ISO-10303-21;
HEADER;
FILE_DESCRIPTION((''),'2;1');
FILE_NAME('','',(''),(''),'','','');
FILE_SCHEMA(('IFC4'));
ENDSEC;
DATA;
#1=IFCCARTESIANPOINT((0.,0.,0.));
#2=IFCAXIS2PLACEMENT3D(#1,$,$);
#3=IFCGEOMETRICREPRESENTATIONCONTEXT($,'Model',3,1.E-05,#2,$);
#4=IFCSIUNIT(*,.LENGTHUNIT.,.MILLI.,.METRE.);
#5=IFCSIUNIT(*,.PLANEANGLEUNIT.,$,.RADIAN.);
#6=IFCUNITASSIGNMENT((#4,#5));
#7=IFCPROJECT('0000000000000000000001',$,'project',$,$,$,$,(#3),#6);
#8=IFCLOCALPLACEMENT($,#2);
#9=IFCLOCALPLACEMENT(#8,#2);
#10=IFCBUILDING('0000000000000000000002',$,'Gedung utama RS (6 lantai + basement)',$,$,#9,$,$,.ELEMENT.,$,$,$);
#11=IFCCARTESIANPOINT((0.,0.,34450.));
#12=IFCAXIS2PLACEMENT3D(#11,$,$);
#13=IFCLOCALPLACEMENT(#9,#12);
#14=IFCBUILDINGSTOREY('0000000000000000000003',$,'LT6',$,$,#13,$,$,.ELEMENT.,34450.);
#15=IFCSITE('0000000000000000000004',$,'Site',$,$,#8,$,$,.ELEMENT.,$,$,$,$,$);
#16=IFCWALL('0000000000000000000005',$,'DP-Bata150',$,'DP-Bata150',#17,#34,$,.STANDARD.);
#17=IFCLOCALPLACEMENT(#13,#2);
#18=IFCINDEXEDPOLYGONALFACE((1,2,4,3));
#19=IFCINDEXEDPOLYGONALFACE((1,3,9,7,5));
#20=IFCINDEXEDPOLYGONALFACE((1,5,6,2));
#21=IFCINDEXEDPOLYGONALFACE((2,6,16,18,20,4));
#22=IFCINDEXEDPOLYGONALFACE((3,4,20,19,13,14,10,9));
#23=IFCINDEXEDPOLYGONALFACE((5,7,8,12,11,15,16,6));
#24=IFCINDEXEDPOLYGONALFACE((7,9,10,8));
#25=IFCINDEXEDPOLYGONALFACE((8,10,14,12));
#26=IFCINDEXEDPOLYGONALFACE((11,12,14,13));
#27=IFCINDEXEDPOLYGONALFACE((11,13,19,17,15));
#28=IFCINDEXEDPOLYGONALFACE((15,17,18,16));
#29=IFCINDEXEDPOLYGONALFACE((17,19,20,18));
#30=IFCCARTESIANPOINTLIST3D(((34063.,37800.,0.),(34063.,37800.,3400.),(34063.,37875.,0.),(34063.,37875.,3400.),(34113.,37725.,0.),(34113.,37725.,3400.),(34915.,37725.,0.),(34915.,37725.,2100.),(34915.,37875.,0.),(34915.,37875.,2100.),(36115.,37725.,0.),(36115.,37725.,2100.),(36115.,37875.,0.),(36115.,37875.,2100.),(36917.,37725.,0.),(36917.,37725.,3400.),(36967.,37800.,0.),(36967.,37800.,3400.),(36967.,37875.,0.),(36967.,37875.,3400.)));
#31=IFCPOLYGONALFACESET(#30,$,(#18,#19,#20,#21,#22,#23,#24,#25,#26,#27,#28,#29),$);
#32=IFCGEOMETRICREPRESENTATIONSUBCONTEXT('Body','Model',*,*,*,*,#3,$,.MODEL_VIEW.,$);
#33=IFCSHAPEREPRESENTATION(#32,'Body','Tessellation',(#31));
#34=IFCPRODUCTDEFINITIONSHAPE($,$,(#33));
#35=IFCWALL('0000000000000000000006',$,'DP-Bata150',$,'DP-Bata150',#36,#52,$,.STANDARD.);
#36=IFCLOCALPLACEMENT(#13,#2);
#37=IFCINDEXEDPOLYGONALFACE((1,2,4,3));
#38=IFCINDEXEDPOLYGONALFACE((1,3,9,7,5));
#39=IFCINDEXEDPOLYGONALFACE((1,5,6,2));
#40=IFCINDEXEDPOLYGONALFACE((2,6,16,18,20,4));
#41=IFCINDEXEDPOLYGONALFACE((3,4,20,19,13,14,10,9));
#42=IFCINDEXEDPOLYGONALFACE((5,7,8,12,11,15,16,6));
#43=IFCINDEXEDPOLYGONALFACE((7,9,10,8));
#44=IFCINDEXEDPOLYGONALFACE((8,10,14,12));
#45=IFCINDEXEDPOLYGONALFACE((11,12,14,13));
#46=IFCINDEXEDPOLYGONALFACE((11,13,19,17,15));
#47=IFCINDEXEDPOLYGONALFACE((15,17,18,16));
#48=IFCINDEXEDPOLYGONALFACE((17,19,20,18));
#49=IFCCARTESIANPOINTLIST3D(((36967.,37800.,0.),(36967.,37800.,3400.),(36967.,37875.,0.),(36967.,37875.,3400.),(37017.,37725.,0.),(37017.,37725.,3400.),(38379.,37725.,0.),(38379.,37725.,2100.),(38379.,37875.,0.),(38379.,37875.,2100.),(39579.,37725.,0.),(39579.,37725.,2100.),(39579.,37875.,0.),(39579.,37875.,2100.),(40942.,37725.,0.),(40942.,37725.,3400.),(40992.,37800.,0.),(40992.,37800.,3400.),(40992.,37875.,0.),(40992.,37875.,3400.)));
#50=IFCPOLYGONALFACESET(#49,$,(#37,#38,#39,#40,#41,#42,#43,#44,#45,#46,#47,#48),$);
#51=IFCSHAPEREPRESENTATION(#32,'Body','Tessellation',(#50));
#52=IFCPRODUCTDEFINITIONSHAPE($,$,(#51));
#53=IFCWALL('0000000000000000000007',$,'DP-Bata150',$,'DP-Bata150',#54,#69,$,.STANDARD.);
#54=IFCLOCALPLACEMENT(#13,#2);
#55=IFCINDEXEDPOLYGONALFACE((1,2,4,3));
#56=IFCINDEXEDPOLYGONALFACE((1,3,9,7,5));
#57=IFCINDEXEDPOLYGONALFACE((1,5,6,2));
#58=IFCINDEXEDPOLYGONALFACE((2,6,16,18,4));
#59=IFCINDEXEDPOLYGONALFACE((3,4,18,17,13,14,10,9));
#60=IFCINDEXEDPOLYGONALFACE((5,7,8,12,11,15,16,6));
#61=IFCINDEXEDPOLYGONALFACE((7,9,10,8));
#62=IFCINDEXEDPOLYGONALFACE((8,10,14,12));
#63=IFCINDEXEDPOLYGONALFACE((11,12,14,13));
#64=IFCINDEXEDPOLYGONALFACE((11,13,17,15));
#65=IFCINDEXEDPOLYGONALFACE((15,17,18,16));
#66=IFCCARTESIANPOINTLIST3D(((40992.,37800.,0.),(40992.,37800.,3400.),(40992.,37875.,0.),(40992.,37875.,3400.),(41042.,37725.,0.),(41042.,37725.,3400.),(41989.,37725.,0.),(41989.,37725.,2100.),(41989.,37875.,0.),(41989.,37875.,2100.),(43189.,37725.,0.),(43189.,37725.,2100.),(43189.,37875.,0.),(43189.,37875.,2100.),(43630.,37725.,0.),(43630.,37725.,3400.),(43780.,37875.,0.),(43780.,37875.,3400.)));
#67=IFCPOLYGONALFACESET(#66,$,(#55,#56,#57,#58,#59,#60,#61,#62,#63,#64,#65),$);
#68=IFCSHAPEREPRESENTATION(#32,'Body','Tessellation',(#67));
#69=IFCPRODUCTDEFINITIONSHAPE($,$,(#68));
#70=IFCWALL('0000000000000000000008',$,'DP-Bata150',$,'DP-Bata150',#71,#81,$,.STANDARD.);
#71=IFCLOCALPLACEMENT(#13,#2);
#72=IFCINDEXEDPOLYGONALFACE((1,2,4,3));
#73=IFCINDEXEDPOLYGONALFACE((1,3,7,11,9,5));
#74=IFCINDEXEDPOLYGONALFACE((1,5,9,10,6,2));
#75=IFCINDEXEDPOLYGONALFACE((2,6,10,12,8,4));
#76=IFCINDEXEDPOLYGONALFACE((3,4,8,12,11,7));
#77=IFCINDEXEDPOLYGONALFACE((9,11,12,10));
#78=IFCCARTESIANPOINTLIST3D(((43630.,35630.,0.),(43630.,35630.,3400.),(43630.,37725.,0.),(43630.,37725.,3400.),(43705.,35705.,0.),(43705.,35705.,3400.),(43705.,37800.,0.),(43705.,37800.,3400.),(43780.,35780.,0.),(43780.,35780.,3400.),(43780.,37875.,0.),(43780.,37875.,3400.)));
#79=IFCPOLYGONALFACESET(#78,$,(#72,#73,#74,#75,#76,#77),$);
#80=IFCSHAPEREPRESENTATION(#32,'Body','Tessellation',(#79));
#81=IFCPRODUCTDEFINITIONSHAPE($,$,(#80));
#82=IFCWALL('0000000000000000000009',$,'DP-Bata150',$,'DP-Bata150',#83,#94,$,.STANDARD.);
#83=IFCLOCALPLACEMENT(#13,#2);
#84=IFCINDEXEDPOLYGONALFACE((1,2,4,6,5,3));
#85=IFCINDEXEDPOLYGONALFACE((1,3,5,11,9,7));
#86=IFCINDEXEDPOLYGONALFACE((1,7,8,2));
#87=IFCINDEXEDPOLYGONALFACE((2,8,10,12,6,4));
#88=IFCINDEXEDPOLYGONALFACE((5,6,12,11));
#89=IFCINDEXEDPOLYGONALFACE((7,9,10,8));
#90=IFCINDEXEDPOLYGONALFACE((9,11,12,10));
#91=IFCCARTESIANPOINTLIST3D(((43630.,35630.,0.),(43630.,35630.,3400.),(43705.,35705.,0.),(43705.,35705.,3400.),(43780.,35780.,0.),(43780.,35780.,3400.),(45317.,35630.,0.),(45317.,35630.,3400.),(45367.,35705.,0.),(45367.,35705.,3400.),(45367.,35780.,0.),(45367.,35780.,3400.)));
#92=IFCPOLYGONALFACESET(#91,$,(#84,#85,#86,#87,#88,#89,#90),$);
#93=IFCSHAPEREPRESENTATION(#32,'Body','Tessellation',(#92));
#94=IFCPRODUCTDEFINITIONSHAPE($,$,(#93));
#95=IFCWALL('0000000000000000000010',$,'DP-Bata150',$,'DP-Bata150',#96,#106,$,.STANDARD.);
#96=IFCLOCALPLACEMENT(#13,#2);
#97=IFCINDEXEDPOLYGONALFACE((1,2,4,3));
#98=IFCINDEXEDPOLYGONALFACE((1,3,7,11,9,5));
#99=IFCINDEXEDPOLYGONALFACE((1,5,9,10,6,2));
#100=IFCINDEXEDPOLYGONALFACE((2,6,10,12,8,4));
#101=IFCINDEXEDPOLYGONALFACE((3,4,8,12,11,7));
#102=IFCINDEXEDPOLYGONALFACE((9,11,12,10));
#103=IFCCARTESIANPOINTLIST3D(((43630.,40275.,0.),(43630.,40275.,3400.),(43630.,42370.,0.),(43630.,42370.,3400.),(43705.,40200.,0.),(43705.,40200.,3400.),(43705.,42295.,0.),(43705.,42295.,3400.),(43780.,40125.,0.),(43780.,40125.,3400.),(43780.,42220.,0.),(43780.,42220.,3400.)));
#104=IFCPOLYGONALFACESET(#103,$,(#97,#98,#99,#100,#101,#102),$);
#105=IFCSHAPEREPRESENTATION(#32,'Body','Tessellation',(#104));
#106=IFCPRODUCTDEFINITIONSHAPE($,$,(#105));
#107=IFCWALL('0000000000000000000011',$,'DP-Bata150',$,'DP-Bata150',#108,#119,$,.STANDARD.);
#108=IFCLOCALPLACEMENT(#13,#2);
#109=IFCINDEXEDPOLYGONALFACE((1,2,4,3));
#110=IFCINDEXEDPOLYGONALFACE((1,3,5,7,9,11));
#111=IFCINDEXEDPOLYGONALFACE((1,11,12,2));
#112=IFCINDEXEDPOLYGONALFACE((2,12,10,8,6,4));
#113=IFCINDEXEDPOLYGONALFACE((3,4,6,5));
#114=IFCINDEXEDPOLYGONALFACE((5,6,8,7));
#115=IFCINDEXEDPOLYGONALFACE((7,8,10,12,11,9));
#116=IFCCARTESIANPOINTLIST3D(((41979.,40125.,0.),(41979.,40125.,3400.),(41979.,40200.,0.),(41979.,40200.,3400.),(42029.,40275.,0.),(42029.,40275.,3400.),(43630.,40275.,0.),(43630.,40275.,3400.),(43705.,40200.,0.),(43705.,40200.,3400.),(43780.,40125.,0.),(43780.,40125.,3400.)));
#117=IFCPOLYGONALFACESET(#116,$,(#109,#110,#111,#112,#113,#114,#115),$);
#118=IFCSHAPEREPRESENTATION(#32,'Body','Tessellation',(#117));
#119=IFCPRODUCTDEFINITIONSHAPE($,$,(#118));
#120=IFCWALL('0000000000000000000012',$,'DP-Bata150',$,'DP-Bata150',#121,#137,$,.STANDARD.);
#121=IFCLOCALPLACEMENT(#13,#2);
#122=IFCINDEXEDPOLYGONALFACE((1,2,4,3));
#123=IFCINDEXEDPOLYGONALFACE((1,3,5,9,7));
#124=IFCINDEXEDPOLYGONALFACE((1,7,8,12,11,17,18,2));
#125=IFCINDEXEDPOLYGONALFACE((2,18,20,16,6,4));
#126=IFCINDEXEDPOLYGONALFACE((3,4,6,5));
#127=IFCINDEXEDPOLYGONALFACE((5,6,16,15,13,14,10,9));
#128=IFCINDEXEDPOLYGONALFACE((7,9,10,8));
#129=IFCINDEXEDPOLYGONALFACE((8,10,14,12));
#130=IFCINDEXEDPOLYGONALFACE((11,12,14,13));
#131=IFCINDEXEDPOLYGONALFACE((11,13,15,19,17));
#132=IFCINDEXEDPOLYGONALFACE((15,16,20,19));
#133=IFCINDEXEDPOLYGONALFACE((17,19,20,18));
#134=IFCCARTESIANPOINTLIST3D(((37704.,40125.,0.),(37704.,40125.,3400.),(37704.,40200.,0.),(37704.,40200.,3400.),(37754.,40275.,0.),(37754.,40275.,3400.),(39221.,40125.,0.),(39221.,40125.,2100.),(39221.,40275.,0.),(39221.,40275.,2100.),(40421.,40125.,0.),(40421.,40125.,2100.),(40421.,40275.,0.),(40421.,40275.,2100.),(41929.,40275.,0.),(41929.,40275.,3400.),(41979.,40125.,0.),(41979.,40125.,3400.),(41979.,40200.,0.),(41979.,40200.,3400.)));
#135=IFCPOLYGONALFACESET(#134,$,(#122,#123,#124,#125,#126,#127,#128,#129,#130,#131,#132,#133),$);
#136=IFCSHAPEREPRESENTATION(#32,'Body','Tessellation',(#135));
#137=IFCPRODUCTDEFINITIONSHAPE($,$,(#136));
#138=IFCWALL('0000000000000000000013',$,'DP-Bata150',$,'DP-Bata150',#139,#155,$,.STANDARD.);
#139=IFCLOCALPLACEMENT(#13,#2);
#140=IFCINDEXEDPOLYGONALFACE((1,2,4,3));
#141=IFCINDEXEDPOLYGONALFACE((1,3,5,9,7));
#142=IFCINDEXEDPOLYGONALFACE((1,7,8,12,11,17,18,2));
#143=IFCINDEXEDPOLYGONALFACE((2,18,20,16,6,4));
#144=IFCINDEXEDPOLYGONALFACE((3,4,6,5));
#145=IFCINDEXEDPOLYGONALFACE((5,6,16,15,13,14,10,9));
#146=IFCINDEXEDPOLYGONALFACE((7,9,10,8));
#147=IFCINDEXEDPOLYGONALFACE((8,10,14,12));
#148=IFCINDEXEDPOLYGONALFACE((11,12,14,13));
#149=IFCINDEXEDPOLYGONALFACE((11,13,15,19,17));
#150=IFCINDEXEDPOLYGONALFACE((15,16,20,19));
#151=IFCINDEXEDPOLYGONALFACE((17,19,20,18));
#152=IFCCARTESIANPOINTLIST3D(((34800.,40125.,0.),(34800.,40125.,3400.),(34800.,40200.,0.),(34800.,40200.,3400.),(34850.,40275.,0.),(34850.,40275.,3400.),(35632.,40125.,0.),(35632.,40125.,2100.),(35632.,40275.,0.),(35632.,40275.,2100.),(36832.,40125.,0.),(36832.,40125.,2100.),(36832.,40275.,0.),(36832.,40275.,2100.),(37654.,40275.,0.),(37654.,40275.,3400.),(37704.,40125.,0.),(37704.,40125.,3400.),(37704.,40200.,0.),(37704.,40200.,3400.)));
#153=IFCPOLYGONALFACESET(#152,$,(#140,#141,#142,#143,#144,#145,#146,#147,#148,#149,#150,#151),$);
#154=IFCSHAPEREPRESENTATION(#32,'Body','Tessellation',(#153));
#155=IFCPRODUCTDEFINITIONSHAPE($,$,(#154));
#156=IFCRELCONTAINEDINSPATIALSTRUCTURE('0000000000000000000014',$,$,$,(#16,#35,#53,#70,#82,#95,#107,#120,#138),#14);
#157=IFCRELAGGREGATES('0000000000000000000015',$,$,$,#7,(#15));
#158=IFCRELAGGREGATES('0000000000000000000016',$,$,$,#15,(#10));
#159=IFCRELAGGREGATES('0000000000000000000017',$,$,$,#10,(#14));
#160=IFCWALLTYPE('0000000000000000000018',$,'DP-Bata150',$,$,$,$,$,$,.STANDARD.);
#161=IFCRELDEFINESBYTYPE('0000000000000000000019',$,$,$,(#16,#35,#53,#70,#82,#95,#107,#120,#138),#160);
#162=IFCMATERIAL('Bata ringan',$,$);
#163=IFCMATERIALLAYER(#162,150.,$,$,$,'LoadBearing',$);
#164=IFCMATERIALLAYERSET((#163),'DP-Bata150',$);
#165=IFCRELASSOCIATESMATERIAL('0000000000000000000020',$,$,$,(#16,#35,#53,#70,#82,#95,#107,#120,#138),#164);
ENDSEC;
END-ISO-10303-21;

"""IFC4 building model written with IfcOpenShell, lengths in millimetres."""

from ifc_helpers import new_model, si_unit, frame, frame_2d, origin, place, context, subcontext, project, spatial, polyline, rectangle, outline, extrude, material, layer, layer_set, layer_usage, type_object, element, save


model = new_model("IFC4")

# Units and contexts
model_context = context("Model", 3, precision=1e-05, world=origin())
body_context = subcontext(model_context, "Body", "Model", "MODEL_VIEW")
ifc_project = project(units=[si_unit("LENGTHUNIT", "METRE", prefix="MILLI"), si_unit("PLANEANGLEUNIT", "RADIAN")], contexts=[model_context])

# Site, building, storey
site_placement = place(None, origin())
site = spatial("IfcSite", under=ifc_project, at=site_placement, Name="Site", CompositionType="ELEMENT")
building_placement = place(site_placement, origin())
building = spatial("IfcBuilding", under=site, at=building_placement, Name="Gedung utama RS (6 lantai + basement)", CompositionType="ELEMENT")
storey_placement = place(building_placement, frame((0.0, 0.0, 34450.0)))
storey = spatial("IfcBuildingStorey", under=building, at=storey_placement, Name="LT6", CompositionType="ELEMENT", Elevation=34450.0)

# Shared definitions
ifc_material_1 = material(Name="Bata ringan")

# Walls, openings
ifc_layer_1 = layer(ifc_material_1, 150.0, Category="LoadBearing")
ifc_layer_set_1 = layer_set([ifc_layer_1], Name="DP-Bata150")
ifc_layer_usage_1 = layer_usage(ifc_layer_set_1, "AXIS2", "NEGATIVE", 75.0)
wall_type_1 = type_object("IfcWallType", Name="DP-Bata150", PredefinedType="STANDARD")
wall_1_placement = place(storey_placement, frame((34063.0, 37800.0, 0.0), z_axis=(0.0, 0.0, 1.0), x_axis=(1.0, 0.0, 0.0)))
wall_1 = element("IfcWall", 1, at=wall_1_placement, inside=storey, type_object=wall_type_1, material=ifc_layer_usage_1, Name="DP-Bata150", ObjectType="DP-Bata150", PredefinedType="STANDARD", context=body_context, shape_type="SweptSolid", body=[
    extrude(outline(polyline([(50.0, -75.0), (0.0, 0.0), (0.0, 75.0), (2904.0, 75.0), (2904.0, 0.0), (2854.0, -75.0), (50.0, -75.0)])), origin(), (0.0, 0.0, 1.0), 3400.0),
])
opening_1_placement = place(wall_1_placement, frame((852.0, 0.0, 0.0), z_axis=(0.0, 0.0, 1.0), x_axis=(1.0, 0.0, 0.0)))
element("IfcOpeningElement", 2, at=opening_1_placement, cuts=wall_1, PredefinedType="OPENING", context=body_context, shape_type="SweptSolid", body=[
    extrude(rectangle(XDim=1200.0, YDim=170.0, at=frame_2d((600.0, 0.0))), origin(), (0.0, 0.0, 1.0), 2100.0),
])
wall_2_placement = place(storey_placement, frame((36967.0, 37800.0, 0.0), z_axis=(0.0, 0.0, 1.0), x_axis=(1.0, 0.0, 0.0)))
wall_2 = element("IfcWall", 3, at=wall_2_placement, inside=storey, type_object=wall_type_1, material=ifc_layer_usage_1, Name="DP-Bata150", ObjectType="DP-Bata150", PredefinedType="STANDARD", context=body_context, shape_type="SweptSolid", body=[
    extrude(outline(polyline([(50.0, -75.0), (0.0, 0.0), (0.0, 75.0), (4025.0, 75.0), (4025.0, 0.0), (3975.0, -75.0), (50.0, -75.0)])), origin(), (0.0, 0.0, 1.0), 3400.0),
])
opening_2_placement = place(wall_2_placement, frame((1412.0, 0.0, 0.0), z_axis=(0.0, 0.0, 1.0), x_axis=(1.0, 0.0, 0.0)))
element("IfcOpeningElement", 4, at=opening_2_placement, cuts=wall_2, PredefinedType="OPENING", context=body_context, shape_type="SweptSolid", body=[
    extrude(rectangle(XDim=1200.0, YDim=170.0, at=frame_2d((600.0, 0.0))), origin(), (0.0, 0.0, 1.0), 2100.0),
])
wall_3_placement = place(storey_placement, frame((40992.0, 37800.0, 0.0), z_axis=(0.0, 0.0, 1.0), x_axis=(1.0, 0.0, 0.0)))
wall_3 = element("IfcWall", 5, at=wall_3_placement, inside=storey, type_object=wall_type_1, material=ifc_layer_usage_1, Name="DP-Bata150", ObjectType="DP-Bata150", PredefinedType="STANDARD", context=body_context, shape_type="SweptSolid", body=[
    extrude(outline(polyline([(50.0, -75.0), (0.0, 0.0), (0.0, 75.0), (2788.0, 75.0), (2713.0, 0.0), (2638.0, -75.0), (50.0, -75.0)])), origin(), (0.0, 0.0, 1.0), 3400.0),
])
opening_3_placement = place(wall_3_placement, frame((997.0, 0.0, 0.0), z_axis=(0.0, 0.0, 1.0), x_axis=(1.0, 0.0, 0.0)))
element("IfcOpeningElement", 6, at=opening_3_placement, cuts=wall_3, PredefinedType="OPENING", context=body_context, shape_type="SweptSolid", body=[
    extrude(rectangle(XDim=1200.0, YDim=170.0, at=frame_2d((600.0, 0.0))), origin(), (0.0, 0.0, 1.0), 2100.0),
])

# Walls
wall_4_placement = place(storey_placement, frame((43705.0, 37800.0, 0.0), z_axis=(0.0, 0.0, 1.0), x_axis=(0.0, -1.0, 0.0)))
element("IfcWall", 7, at=wall_4_placement, inside=storey, type_object=wall_type_1, material=ifc_layer_usage_1, Name="DP-Bata150", ObjectType="DP-Bata150", PredefinedType="STANDARD", context=body_context, shape_type="SweptSolid", body=[
    extrude(outline(polyline([(75.0, -75.0), (0.0, 0.0), (-75.0, 75.0), (2020.0, 75.0), (2095.0, 0.0), (2170.0, -75.0), (75.0, -75.0)])), origin(), (0.0, 0.0, 1.0), 3400.0),
])
wall_5_placement = place(storey_placement, frame((43705.0, 35705.0, 0.0), z_axis=(0.0, 0.0, 1.0), x_axis=(1.0, 0.0, 0.0)))
element("IfcWall", 8, at=wall_5_placement, inside=storey, type_object=wall_type_1, material=ifc_layer_usage_1, Name="DP-Bata150", ObjectType="DP-Bata150", PredefinedType="STANDARD", context=body_context, shape_type="SweptSolid", body=[
    extrude(outline(polyline([(-75.0, -75.0), (0.0, 0.0), (75.0, 75.0), (1662.0, 75.0), (1662.0, 0.0), (1612.0, -75.0), (-75.0, -75.0)])), origin(), (0.0, 0.0, 1.0), 3400.0),
])
wall_6_placement = place(storey_placement, frame((43705.0, 42295.0, 0.0), z_axis=(0.0, 0.0, 1.0), x_axis=(0.0, -1.0, 0.0)))
element("IfcWall", 9, at=wall_6_placement, inside=storey, type_object=wall_type_1, material=ifc_layer_usage_1, Name="DP-Bata150", ObjectType="DP-Bata150", PredefinedType="STANDARD", context=body_context, shape_type="SweptSolid", body=[
    extrude(outline(polyline([(-75.0, -75.0), (0.0, 0.0), (75.0, 75.0), (2170.0, 75.0), (2095.0, 0.0), (2020.0, -75.0), (-75.0, -75.0)])), origin(), (0.0, 0.0, 1.0), 3400.0),
])
wall_7_placement = place(storey_placement, frame((43705.0, 40200.0, 0.0), z_axis=(0.0, 0.0, 1.0), x_axis=(-1.0, 0.0, 0.0)))
element("IfcWall", 10, at=wall_7_placement, inside=storey, type_object=wall_type_1, material=ifc_layer_usage_1, Name="DP-Bata150", ObjectType="DP-Bata150", PredefinedType="STANDARD", context=body_context, shape_type="SweptSolid", body=[
    extrude(outline(polyline([(75.0, -75.0), (0.0, 0.0), (-75.0, 75.0), (1726.0, 75.0), (1726.0, 0.0), (1676.0, -75.0), (75.0, -75.0)])), origin(), (0.0, 0.0, 1.0), 3400.0),
])

# Walls, openings
wall_8_placement = place(storey_placement, frame((41979.0, 40200.0, 0.0), z_axis=(0.0, 0.0, 1.0), x_axis=(-1.0, 0.0, 0.0)))
wall_8 = element("IfcWall", 11, at=wall_8_placement, inside=storey, type_object=wall_type_1, material=ifc_layer_usage_1, Name="DP-Bata150", ObjectType="DP-Bata150", PredefinedType="STANDARD", context=body_context, shape_type="SweptSolid", body=[
    extrude(outline(polyline([(50.0, -75.0), (0.0, 0.0), (0.0, 75.0), (4275.0, 75.0), (4275.0, 0.0), (4225.0, -75.0), (50.0, -75.0)])), origin(), (0.0, 0.0, 1.0), 3400.0),
])
opening_4_placement = place(wall_8_placement, frame((1558.0, 0.0, 0.0), z_axis=(0.0, 0.0, 1.0), x_axis=(1.0, 0.0, 0.0)))
element("IfcOpeningElement", 12, at=opening_4_placement, cuts=wall_8, PredefinedType="OPENING", context=body_context, shape_type="SweptSolid", body=[
    extrude(rectangle(XDim=1200.0, YDim=170.0, at=frame_2d((600.0, 0.0))), origin(), (0.0, 0.0, 1.0), 2100.0),
])
wall_9_placement = place(storey_placement, frame((37704.0, 40200.0, 0.0), z_axis=(0.0, 0.0, 1.0), x_axis=(-1.0, 0.0, 0.0)))
wall_9 = element("IfcWall", 13, at=wall_9_placement, inside=storey, type_object=wall_type_1, material=ifc_layer_usage_1, Name="DP-Bata150", ObjectType="DP-Bata150", PredefinedType="STANDARD", context=body_context, shape_type="SweptSolid", body=[
    extrude(outline(polyline([(50.0, -75.0), (0.0, 0.0), (0.0, 75.0), (2904.0, 75.0), (2904.0, 0.0), (2854.0, -75.0), (50.0, -75.0)])), origin(), (0.0, 0.0, 1.0), 3400.0),
])
opening_5_placement = place(wall_9_placement, frame((872.0, 0.0, 0.0), z_axis=(0.0, 0.0, 1.0), x_axis=(1.0, 0.0, 0.0)))
element("IfcOpeningElement", 14, at=opening_5_placement, cuts=wall_9, PredefinedType="OPENING", context=body_context, shape_type="SweptSolid", body=[
    extrude(rectangle(XDim=1200.0, YDim=170.0, at=frame_2d((600.0, 0.0))), origin(), (0.0, 0.0, 1.0), 2100.0),
])

save(model, "model.ifc")
